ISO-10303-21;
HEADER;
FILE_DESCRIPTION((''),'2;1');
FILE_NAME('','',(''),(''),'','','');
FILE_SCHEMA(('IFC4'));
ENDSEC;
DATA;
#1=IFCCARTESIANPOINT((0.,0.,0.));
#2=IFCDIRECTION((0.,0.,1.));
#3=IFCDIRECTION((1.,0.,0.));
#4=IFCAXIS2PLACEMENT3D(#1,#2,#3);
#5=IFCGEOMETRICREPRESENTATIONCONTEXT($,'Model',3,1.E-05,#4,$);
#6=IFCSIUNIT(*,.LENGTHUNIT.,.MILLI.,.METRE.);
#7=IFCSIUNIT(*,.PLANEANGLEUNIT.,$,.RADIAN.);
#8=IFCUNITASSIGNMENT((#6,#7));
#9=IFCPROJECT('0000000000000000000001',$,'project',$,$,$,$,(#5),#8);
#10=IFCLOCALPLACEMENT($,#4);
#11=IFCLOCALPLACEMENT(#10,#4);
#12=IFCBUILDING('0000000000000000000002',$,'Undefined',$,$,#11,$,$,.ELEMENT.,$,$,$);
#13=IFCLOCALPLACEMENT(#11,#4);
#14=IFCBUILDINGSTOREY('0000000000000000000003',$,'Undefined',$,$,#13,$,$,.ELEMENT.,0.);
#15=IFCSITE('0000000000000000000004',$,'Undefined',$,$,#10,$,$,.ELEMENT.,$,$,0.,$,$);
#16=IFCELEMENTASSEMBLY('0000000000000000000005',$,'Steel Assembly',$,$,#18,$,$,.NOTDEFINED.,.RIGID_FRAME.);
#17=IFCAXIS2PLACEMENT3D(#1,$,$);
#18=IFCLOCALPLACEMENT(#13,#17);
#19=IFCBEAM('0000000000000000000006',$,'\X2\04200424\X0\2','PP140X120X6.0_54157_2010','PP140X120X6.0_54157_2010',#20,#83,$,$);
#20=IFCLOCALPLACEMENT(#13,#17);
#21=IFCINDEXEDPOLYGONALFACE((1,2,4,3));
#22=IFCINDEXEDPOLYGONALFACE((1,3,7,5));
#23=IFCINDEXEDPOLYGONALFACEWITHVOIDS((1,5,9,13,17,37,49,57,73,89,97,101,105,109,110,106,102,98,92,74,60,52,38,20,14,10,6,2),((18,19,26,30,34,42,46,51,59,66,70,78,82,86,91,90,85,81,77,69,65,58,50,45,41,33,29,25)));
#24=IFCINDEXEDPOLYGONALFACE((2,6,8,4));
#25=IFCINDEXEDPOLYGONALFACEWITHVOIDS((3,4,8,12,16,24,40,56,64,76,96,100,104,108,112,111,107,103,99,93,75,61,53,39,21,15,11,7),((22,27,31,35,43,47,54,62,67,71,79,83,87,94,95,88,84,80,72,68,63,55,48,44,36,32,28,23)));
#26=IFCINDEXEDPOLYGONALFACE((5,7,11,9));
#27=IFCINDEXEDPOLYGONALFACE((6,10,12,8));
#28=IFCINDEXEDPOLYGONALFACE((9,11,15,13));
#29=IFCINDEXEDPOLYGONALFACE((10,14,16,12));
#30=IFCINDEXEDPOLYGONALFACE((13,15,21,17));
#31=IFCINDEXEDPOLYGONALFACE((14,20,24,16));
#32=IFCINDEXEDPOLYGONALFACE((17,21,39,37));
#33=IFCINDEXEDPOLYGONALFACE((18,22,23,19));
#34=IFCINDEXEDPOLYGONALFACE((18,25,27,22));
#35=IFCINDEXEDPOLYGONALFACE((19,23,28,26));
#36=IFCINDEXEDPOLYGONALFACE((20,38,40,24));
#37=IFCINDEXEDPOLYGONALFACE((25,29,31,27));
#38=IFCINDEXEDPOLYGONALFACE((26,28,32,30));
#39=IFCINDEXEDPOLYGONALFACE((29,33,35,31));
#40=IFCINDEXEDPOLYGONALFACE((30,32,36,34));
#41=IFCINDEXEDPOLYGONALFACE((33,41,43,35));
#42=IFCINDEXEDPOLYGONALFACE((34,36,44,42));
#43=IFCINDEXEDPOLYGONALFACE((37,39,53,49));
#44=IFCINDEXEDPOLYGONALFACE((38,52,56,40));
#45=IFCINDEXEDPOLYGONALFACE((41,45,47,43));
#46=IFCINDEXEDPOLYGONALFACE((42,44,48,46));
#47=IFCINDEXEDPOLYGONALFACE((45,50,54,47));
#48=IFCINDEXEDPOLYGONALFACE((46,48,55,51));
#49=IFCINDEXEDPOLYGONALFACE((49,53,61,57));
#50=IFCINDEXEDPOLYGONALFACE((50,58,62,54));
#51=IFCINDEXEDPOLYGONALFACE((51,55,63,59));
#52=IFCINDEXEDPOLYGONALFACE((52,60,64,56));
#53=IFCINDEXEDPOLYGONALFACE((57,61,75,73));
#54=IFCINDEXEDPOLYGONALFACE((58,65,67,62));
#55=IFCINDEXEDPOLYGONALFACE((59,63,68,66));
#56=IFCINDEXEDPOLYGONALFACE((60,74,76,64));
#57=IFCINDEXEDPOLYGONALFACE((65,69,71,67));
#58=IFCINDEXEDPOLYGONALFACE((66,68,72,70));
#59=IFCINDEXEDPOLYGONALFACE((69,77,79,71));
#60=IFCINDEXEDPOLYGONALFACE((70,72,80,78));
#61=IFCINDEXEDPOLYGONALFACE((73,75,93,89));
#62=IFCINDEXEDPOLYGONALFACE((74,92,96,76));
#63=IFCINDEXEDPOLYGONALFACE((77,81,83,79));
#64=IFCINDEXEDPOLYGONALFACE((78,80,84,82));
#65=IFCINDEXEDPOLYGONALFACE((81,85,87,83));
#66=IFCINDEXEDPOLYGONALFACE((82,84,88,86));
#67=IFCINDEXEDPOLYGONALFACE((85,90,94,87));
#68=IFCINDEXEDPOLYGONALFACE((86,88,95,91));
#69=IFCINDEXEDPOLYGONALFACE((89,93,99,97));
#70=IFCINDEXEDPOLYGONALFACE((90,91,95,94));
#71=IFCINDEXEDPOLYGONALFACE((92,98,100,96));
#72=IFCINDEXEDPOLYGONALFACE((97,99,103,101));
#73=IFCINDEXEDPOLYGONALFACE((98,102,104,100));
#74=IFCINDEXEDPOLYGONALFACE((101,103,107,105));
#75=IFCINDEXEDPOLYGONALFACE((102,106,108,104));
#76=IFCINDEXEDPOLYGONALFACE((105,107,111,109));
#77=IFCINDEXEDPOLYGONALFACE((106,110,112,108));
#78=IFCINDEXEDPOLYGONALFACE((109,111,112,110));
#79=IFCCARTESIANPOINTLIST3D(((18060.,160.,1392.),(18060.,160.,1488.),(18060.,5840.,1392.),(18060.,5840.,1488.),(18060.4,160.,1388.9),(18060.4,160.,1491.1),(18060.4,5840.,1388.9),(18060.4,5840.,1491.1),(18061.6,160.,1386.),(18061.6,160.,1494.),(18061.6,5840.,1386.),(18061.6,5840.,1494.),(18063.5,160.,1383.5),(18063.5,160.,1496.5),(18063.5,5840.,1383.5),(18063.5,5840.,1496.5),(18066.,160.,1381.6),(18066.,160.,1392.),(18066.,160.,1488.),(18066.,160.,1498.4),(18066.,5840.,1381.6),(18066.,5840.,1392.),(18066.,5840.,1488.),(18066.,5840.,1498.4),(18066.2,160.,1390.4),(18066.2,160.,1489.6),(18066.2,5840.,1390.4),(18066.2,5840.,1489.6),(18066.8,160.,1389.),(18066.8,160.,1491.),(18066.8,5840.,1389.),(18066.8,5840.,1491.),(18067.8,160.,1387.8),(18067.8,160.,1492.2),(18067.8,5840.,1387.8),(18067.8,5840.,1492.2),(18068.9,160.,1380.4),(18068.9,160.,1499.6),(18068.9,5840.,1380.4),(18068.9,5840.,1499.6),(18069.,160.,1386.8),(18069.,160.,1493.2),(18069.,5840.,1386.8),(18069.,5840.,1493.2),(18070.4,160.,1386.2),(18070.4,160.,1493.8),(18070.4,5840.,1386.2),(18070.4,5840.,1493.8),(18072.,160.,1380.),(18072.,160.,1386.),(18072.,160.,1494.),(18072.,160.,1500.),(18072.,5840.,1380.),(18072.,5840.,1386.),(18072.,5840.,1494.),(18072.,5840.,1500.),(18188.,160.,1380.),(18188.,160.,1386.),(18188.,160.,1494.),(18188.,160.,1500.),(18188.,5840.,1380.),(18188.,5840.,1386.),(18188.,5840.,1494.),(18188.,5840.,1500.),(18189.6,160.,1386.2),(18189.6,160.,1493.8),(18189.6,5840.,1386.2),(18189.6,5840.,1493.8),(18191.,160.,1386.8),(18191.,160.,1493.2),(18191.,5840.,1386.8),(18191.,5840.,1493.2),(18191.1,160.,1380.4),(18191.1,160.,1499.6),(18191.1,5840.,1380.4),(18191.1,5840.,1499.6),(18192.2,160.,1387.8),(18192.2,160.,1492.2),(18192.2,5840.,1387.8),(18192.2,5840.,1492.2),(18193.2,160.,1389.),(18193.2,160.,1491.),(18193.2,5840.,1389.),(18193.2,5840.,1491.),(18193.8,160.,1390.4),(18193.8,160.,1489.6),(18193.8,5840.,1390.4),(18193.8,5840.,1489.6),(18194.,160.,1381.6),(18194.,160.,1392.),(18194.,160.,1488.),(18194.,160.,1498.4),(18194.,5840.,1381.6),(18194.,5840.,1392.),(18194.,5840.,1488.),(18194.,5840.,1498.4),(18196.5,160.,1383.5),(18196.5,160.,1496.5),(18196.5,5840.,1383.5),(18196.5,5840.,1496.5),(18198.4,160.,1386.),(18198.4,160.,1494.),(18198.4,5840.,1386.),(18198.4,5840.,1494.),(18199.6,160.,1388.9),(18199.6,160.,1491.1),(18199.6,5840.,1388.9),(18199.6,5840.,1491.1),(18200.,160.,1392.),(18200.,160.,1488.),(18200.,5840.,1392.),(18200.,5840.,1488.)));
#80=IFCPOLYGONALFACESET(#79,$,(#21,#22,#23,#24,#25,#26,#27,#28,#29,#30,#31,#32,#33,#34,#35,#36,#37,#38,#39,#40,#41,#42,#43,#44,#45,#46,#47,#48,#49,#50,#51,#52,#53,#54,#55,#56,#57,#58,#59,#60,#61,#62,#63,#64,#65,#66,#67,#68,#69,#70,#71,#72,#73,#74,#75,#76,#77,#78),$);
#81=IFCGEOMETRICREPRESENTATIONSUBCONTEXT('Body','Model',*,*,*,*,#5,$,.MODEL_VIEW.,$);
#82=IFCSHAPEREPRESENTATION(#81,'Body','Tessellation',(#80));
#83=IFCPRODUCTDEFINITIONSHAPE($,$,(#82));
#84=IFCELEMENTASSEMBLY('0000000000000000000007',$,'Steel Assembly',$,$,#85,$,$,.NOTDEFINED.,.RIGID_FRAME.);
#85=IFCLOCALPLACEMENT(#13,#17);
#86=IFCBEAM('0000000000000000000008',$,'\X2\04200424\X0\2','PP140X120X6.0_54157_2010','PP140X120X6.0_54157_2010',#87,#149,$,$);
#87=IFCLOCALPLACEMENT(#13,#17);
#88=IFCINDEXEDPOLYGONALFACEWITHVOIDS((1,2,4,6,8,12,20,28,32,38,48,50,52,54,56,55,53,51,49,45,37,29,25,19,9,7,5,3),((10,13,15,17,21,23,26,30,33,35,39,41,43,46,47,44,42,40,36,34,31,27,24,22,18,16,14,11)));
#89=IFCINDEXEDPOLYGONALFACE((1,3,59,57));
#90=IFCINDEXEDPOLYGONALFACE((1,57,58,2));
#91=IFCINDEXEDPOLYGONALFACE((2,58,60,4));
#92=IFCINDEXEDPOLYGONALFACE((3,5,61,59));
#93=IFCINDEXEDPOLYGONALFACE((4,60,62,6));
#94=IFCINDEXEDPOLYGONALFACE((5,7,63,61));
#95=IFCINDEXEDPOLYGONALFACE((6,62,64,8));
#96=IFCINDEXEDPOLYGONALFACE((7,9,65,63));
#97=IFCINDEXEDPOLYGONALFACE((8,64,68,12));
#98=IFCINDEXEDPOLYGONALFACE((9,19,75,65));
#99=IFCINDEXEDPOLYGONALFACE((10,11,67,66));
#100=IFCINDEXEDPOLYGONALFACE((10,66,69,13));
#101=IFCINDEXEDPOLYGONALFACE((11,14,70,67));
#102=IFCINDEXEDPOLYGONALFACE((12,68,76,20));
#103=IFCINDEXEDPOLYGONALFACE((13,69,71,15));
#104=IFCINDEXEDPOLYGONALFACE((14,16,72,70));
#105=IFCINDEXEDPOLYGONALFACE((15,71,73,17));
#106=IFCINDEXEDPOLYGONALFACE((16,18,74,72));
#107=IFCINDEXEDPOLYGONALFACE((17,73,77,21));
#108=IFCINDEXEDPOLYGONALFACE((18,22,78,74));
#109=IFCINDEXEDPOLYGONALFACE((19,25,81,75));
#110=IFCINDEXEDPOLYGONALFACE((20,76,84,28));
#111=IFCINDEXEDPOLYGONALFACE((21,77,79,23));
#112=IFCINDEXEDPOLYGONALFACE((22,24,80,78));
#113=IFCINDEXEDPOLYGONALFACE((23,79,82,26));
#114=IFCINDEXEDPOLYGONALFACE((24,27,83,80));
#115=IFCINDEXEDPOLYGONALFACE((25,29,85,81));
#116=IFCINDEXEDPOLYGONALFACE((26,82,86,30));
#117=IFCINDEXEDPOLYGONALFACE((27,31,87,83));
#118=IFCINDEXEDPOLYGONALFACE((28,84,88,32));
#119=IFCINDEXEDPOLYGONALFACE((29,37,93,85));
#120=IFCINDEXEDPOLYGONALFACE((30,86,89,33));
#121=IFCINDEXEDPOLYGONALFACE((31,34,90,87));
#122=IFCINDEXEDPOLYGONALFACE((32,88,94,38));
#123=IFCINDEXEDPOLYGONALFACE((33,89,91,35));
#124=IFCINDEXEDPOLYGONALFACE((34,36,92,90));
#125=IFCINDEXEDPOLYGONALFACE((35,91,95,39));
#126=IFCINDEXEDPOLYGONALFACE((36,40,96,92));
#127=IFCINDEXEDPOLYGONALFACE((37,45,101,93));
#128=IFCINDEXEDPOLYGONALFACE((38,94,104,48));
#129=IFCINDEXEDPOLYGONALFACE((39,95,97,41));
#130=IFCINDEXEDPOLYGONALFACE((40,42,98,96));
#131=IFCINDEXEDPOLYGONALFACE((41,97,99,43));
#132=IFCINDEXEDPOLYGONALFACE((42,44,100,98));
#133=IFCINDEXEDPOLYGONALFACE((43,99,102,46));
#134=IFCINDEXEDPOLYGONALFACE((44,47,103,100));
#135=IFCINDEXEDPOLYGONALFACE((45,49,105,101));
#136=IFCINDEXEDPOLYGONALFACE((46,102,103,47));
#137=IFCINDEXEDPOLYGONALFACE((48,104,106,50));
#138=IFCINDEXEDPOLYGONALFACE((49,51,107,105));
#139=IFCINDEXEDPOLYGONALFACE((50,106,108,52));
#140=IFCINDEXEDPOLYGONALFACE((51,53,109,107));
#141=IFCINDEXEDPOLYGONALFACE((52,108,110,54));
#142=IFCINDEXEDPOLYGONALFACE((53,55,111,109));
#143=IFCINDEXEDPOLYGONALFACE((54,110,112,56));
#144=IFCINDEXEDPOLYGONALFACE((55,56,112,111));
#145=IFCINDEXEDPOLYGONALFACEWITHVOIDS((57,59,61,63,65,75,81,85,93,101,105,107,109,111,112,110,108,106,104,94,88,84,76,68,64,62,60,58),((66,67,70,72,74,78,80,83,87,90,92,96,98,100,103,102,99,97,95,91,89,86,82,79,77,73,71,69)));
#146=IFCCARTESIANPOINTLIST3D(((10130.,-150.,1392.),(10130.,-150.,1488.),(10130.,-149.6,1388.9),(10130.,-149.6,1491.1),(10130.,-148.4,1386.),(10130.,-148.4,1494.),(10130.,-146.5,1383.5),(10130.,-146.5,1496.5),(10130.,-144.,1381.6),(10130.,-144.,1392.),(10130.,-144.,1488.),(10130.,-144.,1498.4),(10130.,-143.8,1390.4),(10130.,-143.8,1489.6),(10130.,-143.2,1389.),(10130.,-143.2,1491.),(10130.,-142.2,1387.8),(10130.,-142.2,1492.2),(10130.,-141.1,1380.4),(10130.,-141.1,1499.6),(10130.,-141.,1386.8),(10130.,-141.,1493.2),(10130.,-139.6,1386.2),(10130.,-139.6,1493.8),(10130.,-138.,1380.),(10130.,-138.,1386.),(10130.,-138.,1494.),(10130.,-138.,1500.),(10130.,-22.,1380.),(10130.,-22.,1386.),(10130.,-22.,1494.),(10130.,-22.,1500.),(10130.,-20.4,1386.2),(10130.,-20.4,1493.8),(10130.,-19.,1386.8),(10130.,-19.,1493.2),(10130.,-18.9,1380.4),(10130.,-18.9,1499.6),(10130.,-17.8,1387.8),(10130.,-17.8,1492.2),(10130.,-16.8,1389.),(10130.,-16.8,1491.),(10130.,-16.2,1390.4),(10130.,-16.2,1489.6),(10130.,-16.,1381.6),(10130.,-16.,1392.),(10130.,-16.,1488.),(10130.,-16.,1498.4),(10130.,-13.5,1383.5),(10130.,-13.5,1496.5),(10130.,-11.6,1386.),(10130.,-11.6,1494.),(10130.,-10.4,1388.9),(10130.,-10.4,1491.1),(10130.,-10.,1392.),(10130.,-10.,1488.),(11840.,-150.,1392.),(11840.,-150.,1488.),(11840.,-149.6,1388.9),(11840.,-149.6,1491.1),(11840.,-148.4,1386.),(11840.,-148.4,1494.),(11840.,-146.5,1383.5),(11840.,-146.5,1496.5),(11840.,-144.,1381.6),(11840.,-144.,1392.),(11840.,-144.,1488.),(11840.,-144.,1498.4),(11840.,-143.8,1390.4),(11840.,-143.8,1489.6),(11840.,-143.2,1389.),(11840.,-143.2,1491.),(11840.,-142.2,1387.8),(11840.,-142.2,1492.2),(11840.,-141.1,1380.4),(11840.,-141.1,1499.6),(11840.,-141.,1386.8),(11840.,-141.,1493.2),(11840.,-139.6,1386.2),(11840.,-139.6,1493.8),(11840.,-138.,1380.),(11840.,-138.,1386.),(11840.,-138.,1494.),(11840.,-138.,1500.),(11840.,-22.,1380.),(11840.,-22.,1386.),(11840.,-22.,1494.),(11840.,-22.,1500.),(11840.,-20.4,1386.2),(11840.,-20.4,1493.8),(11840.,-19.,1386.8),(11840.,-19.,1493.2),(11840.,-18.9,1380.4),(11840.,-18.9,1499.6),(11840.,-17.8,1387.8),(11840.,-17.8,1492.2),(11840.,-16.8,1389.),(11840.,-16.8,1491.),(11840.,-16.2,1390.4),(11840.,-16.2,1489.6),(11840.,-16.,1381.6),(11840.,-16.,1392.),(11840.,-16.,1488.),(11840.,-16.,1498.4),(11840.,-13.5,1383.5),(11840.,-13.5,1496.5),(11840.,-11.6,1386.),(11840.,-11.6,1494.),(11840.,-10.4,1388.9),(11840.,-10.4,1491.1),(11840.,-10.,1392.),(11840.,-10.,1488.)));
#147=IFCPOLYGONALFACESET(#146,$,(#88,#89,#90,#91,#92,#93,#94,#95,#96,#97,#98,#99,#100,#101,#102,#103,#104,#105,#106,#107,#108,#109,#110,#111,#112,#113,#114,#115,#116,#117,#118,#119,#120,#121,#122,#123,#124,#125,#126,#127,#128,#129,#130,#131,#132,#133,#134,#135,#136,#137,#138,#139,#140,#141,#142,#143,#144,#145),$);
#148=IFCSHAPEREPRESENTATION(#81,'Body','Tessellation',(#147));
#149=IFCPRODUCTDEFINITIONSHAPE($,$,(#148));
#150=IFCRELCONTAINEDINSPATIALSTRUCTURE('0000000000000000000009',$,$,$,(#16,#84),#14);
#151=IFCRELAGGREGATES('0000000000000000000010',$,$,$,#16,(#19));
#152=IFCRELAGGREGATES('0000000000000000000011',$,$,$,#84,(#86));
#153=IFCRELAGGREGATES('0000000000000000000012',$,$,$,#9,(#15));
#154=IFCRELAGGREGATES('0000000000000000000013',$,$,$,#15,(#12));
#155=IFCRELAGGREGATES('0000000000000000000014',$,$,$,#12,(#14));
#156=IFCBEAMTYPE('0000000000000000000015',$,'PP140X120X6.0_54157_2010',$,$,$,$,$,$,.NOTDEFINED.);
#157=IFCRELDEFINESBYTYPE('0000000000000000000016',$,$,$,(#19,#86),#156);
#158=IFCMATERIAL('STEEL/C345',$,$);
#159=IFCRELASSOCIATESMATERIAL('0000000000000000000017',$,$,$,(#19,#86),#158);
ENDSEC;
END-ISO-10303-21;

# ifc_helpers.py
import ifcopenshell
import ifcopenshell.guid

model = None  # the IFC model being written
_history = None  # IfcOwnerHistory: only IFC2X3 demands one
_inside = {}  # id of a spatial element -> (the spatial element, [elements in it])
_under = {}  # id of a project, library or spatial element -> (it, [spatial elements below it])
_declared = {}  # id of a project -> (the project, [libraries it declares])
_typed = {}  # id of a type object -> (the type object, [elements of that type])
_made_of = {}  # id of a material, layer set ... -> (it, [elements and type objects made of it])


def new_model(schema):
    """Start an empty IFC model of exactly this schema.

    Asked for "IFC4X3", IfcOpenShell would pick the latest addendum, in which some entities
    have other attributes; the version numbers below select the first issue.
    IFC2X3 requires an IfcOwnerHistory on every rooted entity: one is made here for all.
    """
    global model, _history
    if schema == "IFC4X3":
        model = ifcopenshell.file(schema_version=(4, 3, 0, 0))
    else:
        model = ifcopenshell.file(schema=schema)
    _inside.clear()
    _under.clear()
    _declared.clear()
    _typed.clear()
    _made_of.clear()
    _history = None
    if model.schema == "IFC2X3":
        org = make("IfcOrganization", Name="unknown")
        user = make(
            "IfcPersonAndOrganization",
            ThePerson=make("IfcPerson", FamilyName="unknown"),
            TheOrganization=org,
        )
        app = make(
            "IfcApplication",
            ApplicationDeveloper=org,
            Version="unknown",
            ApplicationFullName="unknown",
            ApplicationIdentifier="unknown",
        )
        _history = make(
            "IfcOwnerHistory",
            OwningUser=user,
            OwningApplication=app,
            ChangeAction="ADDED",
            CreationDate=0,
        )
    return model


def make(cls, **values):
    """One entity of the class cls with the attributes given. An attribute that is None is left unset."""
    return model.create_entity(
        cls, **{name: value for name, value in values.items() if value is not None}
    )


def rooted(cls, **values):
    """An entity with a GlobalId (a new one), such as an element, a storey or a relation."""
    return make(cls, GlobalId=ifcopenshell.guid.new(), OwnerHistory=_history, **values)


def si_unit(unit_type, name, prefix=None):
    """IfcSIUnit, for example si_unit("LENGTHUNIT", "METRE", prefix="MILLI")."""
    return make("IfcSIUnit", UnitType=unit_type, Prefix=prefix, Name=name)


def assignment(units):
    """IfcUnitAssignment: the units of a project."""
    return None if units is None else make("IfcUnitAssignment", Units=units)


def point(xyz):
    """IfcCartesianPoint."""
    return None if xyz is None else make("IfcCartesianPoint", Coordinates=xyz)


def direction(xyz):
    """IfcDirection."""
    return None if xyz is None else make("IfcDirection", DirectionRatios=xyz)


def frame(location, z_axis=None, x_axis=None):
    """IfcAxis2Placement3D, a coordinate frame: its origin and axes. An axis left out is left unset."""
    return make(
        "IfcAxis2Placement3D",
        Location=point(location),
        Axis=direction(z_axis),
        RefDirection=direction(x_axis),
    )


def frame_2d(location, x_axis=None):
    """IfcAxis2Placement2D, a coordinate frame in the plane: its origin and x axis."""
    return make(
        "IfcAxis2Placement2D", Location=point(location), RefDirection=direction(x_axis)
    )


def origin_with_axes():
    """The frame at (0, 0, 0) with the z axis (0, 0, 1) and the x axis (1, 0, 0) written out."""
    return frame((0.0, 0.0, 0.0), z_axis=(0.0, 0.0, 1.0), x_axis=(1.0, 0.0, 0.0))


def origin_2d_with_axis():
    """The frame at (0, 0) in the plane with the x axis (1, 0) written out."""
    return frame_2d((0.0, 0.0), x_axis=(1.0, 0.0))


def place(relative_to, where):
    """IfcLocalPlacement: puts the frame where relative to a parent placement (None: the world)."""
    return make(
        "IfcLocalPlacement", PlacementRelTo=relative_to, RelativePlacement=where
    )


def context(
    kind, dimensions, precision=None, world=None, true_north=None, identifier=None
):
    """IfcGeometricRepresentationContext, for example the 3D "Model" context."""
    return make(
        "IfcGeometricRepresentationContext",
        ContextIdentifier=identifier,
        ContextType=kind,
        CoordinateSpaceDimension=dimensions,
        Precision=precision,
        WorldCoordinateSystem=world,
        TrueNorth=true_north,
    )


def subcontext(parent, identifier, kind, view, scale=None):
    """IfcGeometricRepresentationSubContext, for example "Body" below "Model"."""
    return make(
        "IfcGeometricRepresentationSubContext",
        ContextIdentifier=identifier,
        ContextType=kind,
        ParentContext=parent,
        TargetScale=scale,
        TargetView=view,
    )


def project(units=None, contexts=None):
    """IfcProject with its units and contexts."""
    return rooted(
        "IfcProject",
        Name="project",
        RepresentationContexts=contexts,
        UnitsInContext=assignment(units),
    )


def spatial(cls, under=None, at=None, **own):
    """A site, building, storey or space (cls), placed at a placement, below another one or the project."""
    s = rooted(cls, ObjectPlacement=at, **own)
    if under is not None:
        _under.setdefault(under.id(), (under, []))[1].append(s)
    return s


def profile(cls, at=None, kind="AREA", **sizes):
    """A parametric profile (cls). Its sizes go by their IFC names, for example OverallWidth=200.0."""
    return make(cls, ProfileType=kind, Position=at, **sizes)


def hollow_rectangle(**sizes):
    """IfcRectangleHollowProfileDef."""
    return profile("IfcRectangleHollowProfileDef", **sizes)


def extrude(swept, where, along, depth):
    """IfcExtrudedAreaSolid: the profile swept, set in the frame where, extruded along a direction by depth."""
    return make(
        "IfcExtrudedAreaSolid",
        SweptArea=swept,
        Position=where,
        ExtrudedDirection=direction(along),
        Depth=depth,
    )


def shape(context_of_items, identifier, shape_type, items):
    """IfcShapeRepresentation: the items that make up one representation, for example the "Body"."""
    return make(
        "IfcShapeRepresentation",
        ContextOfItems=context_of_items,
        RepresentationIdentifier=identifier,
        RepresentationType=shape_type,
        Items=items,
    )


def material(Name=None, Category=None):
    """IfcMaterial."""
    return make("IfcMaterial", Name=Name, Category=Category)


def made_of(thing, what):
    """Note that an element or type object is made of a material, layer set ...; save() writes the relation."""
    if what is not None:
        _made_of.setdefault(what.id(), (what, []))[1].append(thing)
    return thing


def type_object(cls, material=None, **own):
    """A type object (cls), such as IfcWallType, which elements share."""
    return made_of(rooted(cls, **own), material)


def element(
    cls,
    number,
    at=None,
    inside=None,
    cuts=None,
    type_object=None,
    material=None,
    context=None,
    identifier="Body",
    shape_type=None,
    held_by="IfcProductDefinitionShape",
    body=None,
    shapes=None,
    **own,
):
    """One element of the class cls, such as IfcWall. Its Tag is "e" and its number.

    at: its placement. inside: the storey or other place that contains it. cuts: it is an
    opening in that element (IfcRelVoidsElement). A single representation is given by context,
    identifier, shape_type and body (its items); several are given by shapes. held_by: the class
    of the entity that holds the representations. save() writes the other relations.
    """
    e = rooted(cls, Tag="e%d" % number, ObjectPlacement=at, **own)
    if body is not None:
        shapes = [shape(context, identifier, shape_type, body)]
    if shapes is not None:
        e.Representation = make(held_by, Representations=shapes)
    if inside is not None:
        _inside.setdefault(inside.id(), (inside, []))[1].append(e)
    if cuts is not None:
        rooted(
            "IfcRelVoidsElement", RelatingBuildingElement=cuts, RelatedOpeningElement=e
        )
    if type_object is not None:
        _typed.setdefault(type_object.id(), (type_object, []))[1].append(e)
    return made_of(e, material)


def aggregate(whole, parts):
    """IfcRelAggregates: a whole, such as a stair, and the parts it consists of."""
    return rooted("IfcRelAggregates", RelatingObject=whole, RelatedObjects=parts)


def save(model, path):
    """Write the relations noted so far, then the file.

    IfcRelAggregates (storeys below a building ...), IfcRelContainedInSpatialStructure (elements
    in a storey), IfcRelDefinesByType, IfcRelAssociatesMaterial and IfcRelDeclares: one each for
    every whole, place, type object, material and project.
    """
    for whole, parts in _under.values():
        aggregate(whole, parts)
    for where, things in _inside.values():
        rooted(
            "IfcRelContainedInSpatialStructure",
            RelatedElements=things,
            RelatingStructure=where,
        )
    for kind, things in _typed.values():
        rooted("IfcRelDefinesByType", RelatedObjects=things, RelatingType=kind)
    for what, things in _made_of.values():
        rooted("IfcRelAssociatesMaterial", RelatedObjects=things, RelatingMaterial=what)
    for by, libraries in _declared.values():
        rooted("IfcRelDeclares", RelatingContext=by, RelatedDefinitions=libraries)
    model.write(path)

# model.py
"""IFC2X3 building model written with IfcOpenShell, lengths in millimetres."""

from ifc_helpers import new_model, si_unit, frame, origin_with_axes, origin_2d_with_axis, place, context, subcontext, project, spatial, hollow_rectangle, extrude, material, type_object, element, aggregate, save


model = new_model("IFC2X3")

# Units and contexts
model_context = context("Model", 3, precision=1e-05, world=origin_with_axes())
body_context = subcontext(model_context, "Body", "Model", "MODEL_VIEW")
ifc_project = project(units=[si_unit("LENGTHUNIT", "METRE", prefix="MILLI"), si_unit("PLANEANGLEUNIT", "RADIAN")], contexts=[model_context])

# Site, building, storey
site_placement = place(None, origin_with_axes())
site = spatial("IfcSite", under=ifc_project, at=site_placement, Name="Undefined", CompositionType="ELEMENT", RefElevation=0.0)
building_placement = place(site_placement, origin_with_axes())
building = spatial("IfcBuilding", under=site, at=building_placement, Name="Undefined", CompositionType="ELEMENT")
storey_placement = place(building_placement, origin_with_axes())
storey = spatial("IfcBuildingStorey", under=building, at=storey_placement, Name="Undefined", CompositionType="ELEMENT", Elevation=0.0)

# Shared definitions
ifc_material_1 = material(Name="STEEL/C345")

# Element assemblies, beams
beam_type_1 = type_object("IfcBeamType", Name="PP140X120X6.0_54157_2010", PredefinedType="NOTDEFINED")
assembly_1_placement = place(storey_placement, origin_with_axes())
assembly_1 = element("IfcElementAssembly", 1, at=assembly_1_placement, inside=storey, Name="Steel Assembly", AssemblyPlace="NOTDEFINED", PredefinedType="RIGID_FRAME")
beam_1_placement = place(assembly_1_placement, frame((18130.0, 160.0, 1440.0), z_axis=(1.0, 0.0, 0.0), x_axis=(0.0, 1.0, 0.0)))
beam_1 = element("IfcBeam", 2, at=beam_1_placement, type_object=beam_type_1, material=ifc_material_1, Name="РФ2", Description="PP140X120X6.0_54157_2010", ObjectType="PP140X120X6.0_54157_2010", context=body_context, shape_type="SweptSolid", body=[
    extrude(hollow_rectangle(XDim=120.0, YDim=140.0, WallThickness=6.0, InnerFilletRadius=6.0, OuterFilletRadius=12.0, at=origin_2d_with_axis()), frame((5680.0, 0.0, 0.0), z_axis=(-1.0, 0.0, 0.0), x_axis=(0.0, -1.0, 0.0)), (0.0, 0.0, 1.0), 5680.0),
])
aggregate(assembly_1, [beam_1])
assembly_2_placement = place(storey_placement, origin_with_axes())
assembly_2 = element("IfcElementAssembly", 3, at=assembly_2_placement, inside=storey, Name="Steel Assembly", AssemblyPlace="NOTDEFINED", PredefinedType="RIGID_FRAME")
beam_2_placement = place(assembly_2_placement, frame((11840.0, -80.0, 1440.0), z_axis=(0.0, 1.0, 0.0), x_axis=(-1.0, 0.0, 0.0)))
beam_2 = element("IfcBeam", 4, at=beam_2_placement, type_object=beam_type_1, material=ifc_material_1, Name="РФ2", Description="PP140X120X6.0_54157_2010", ObjectType="PP140X120X6.0_54157_2010", context=body_context, shape_type="SweptSolid", body=[
    extrude(hollow_rectangle(XDim=120.0, YDim=140.0, WallThickness=6.0, InnerFilletRadius=6.0, OuterFilletRadius=12.0, at=origin_2d_with_axis()), frame((1710.0, 0.0, 0.0), z_axis=(-1.0, 0.0, 0.0), x_axis=(0.0, -1.0, 0.0)), (0.0, 0.0, 1.0), 1710.0),
])
aggregate(assembly_2, [beam_2])

save(model, "model.ifc")
